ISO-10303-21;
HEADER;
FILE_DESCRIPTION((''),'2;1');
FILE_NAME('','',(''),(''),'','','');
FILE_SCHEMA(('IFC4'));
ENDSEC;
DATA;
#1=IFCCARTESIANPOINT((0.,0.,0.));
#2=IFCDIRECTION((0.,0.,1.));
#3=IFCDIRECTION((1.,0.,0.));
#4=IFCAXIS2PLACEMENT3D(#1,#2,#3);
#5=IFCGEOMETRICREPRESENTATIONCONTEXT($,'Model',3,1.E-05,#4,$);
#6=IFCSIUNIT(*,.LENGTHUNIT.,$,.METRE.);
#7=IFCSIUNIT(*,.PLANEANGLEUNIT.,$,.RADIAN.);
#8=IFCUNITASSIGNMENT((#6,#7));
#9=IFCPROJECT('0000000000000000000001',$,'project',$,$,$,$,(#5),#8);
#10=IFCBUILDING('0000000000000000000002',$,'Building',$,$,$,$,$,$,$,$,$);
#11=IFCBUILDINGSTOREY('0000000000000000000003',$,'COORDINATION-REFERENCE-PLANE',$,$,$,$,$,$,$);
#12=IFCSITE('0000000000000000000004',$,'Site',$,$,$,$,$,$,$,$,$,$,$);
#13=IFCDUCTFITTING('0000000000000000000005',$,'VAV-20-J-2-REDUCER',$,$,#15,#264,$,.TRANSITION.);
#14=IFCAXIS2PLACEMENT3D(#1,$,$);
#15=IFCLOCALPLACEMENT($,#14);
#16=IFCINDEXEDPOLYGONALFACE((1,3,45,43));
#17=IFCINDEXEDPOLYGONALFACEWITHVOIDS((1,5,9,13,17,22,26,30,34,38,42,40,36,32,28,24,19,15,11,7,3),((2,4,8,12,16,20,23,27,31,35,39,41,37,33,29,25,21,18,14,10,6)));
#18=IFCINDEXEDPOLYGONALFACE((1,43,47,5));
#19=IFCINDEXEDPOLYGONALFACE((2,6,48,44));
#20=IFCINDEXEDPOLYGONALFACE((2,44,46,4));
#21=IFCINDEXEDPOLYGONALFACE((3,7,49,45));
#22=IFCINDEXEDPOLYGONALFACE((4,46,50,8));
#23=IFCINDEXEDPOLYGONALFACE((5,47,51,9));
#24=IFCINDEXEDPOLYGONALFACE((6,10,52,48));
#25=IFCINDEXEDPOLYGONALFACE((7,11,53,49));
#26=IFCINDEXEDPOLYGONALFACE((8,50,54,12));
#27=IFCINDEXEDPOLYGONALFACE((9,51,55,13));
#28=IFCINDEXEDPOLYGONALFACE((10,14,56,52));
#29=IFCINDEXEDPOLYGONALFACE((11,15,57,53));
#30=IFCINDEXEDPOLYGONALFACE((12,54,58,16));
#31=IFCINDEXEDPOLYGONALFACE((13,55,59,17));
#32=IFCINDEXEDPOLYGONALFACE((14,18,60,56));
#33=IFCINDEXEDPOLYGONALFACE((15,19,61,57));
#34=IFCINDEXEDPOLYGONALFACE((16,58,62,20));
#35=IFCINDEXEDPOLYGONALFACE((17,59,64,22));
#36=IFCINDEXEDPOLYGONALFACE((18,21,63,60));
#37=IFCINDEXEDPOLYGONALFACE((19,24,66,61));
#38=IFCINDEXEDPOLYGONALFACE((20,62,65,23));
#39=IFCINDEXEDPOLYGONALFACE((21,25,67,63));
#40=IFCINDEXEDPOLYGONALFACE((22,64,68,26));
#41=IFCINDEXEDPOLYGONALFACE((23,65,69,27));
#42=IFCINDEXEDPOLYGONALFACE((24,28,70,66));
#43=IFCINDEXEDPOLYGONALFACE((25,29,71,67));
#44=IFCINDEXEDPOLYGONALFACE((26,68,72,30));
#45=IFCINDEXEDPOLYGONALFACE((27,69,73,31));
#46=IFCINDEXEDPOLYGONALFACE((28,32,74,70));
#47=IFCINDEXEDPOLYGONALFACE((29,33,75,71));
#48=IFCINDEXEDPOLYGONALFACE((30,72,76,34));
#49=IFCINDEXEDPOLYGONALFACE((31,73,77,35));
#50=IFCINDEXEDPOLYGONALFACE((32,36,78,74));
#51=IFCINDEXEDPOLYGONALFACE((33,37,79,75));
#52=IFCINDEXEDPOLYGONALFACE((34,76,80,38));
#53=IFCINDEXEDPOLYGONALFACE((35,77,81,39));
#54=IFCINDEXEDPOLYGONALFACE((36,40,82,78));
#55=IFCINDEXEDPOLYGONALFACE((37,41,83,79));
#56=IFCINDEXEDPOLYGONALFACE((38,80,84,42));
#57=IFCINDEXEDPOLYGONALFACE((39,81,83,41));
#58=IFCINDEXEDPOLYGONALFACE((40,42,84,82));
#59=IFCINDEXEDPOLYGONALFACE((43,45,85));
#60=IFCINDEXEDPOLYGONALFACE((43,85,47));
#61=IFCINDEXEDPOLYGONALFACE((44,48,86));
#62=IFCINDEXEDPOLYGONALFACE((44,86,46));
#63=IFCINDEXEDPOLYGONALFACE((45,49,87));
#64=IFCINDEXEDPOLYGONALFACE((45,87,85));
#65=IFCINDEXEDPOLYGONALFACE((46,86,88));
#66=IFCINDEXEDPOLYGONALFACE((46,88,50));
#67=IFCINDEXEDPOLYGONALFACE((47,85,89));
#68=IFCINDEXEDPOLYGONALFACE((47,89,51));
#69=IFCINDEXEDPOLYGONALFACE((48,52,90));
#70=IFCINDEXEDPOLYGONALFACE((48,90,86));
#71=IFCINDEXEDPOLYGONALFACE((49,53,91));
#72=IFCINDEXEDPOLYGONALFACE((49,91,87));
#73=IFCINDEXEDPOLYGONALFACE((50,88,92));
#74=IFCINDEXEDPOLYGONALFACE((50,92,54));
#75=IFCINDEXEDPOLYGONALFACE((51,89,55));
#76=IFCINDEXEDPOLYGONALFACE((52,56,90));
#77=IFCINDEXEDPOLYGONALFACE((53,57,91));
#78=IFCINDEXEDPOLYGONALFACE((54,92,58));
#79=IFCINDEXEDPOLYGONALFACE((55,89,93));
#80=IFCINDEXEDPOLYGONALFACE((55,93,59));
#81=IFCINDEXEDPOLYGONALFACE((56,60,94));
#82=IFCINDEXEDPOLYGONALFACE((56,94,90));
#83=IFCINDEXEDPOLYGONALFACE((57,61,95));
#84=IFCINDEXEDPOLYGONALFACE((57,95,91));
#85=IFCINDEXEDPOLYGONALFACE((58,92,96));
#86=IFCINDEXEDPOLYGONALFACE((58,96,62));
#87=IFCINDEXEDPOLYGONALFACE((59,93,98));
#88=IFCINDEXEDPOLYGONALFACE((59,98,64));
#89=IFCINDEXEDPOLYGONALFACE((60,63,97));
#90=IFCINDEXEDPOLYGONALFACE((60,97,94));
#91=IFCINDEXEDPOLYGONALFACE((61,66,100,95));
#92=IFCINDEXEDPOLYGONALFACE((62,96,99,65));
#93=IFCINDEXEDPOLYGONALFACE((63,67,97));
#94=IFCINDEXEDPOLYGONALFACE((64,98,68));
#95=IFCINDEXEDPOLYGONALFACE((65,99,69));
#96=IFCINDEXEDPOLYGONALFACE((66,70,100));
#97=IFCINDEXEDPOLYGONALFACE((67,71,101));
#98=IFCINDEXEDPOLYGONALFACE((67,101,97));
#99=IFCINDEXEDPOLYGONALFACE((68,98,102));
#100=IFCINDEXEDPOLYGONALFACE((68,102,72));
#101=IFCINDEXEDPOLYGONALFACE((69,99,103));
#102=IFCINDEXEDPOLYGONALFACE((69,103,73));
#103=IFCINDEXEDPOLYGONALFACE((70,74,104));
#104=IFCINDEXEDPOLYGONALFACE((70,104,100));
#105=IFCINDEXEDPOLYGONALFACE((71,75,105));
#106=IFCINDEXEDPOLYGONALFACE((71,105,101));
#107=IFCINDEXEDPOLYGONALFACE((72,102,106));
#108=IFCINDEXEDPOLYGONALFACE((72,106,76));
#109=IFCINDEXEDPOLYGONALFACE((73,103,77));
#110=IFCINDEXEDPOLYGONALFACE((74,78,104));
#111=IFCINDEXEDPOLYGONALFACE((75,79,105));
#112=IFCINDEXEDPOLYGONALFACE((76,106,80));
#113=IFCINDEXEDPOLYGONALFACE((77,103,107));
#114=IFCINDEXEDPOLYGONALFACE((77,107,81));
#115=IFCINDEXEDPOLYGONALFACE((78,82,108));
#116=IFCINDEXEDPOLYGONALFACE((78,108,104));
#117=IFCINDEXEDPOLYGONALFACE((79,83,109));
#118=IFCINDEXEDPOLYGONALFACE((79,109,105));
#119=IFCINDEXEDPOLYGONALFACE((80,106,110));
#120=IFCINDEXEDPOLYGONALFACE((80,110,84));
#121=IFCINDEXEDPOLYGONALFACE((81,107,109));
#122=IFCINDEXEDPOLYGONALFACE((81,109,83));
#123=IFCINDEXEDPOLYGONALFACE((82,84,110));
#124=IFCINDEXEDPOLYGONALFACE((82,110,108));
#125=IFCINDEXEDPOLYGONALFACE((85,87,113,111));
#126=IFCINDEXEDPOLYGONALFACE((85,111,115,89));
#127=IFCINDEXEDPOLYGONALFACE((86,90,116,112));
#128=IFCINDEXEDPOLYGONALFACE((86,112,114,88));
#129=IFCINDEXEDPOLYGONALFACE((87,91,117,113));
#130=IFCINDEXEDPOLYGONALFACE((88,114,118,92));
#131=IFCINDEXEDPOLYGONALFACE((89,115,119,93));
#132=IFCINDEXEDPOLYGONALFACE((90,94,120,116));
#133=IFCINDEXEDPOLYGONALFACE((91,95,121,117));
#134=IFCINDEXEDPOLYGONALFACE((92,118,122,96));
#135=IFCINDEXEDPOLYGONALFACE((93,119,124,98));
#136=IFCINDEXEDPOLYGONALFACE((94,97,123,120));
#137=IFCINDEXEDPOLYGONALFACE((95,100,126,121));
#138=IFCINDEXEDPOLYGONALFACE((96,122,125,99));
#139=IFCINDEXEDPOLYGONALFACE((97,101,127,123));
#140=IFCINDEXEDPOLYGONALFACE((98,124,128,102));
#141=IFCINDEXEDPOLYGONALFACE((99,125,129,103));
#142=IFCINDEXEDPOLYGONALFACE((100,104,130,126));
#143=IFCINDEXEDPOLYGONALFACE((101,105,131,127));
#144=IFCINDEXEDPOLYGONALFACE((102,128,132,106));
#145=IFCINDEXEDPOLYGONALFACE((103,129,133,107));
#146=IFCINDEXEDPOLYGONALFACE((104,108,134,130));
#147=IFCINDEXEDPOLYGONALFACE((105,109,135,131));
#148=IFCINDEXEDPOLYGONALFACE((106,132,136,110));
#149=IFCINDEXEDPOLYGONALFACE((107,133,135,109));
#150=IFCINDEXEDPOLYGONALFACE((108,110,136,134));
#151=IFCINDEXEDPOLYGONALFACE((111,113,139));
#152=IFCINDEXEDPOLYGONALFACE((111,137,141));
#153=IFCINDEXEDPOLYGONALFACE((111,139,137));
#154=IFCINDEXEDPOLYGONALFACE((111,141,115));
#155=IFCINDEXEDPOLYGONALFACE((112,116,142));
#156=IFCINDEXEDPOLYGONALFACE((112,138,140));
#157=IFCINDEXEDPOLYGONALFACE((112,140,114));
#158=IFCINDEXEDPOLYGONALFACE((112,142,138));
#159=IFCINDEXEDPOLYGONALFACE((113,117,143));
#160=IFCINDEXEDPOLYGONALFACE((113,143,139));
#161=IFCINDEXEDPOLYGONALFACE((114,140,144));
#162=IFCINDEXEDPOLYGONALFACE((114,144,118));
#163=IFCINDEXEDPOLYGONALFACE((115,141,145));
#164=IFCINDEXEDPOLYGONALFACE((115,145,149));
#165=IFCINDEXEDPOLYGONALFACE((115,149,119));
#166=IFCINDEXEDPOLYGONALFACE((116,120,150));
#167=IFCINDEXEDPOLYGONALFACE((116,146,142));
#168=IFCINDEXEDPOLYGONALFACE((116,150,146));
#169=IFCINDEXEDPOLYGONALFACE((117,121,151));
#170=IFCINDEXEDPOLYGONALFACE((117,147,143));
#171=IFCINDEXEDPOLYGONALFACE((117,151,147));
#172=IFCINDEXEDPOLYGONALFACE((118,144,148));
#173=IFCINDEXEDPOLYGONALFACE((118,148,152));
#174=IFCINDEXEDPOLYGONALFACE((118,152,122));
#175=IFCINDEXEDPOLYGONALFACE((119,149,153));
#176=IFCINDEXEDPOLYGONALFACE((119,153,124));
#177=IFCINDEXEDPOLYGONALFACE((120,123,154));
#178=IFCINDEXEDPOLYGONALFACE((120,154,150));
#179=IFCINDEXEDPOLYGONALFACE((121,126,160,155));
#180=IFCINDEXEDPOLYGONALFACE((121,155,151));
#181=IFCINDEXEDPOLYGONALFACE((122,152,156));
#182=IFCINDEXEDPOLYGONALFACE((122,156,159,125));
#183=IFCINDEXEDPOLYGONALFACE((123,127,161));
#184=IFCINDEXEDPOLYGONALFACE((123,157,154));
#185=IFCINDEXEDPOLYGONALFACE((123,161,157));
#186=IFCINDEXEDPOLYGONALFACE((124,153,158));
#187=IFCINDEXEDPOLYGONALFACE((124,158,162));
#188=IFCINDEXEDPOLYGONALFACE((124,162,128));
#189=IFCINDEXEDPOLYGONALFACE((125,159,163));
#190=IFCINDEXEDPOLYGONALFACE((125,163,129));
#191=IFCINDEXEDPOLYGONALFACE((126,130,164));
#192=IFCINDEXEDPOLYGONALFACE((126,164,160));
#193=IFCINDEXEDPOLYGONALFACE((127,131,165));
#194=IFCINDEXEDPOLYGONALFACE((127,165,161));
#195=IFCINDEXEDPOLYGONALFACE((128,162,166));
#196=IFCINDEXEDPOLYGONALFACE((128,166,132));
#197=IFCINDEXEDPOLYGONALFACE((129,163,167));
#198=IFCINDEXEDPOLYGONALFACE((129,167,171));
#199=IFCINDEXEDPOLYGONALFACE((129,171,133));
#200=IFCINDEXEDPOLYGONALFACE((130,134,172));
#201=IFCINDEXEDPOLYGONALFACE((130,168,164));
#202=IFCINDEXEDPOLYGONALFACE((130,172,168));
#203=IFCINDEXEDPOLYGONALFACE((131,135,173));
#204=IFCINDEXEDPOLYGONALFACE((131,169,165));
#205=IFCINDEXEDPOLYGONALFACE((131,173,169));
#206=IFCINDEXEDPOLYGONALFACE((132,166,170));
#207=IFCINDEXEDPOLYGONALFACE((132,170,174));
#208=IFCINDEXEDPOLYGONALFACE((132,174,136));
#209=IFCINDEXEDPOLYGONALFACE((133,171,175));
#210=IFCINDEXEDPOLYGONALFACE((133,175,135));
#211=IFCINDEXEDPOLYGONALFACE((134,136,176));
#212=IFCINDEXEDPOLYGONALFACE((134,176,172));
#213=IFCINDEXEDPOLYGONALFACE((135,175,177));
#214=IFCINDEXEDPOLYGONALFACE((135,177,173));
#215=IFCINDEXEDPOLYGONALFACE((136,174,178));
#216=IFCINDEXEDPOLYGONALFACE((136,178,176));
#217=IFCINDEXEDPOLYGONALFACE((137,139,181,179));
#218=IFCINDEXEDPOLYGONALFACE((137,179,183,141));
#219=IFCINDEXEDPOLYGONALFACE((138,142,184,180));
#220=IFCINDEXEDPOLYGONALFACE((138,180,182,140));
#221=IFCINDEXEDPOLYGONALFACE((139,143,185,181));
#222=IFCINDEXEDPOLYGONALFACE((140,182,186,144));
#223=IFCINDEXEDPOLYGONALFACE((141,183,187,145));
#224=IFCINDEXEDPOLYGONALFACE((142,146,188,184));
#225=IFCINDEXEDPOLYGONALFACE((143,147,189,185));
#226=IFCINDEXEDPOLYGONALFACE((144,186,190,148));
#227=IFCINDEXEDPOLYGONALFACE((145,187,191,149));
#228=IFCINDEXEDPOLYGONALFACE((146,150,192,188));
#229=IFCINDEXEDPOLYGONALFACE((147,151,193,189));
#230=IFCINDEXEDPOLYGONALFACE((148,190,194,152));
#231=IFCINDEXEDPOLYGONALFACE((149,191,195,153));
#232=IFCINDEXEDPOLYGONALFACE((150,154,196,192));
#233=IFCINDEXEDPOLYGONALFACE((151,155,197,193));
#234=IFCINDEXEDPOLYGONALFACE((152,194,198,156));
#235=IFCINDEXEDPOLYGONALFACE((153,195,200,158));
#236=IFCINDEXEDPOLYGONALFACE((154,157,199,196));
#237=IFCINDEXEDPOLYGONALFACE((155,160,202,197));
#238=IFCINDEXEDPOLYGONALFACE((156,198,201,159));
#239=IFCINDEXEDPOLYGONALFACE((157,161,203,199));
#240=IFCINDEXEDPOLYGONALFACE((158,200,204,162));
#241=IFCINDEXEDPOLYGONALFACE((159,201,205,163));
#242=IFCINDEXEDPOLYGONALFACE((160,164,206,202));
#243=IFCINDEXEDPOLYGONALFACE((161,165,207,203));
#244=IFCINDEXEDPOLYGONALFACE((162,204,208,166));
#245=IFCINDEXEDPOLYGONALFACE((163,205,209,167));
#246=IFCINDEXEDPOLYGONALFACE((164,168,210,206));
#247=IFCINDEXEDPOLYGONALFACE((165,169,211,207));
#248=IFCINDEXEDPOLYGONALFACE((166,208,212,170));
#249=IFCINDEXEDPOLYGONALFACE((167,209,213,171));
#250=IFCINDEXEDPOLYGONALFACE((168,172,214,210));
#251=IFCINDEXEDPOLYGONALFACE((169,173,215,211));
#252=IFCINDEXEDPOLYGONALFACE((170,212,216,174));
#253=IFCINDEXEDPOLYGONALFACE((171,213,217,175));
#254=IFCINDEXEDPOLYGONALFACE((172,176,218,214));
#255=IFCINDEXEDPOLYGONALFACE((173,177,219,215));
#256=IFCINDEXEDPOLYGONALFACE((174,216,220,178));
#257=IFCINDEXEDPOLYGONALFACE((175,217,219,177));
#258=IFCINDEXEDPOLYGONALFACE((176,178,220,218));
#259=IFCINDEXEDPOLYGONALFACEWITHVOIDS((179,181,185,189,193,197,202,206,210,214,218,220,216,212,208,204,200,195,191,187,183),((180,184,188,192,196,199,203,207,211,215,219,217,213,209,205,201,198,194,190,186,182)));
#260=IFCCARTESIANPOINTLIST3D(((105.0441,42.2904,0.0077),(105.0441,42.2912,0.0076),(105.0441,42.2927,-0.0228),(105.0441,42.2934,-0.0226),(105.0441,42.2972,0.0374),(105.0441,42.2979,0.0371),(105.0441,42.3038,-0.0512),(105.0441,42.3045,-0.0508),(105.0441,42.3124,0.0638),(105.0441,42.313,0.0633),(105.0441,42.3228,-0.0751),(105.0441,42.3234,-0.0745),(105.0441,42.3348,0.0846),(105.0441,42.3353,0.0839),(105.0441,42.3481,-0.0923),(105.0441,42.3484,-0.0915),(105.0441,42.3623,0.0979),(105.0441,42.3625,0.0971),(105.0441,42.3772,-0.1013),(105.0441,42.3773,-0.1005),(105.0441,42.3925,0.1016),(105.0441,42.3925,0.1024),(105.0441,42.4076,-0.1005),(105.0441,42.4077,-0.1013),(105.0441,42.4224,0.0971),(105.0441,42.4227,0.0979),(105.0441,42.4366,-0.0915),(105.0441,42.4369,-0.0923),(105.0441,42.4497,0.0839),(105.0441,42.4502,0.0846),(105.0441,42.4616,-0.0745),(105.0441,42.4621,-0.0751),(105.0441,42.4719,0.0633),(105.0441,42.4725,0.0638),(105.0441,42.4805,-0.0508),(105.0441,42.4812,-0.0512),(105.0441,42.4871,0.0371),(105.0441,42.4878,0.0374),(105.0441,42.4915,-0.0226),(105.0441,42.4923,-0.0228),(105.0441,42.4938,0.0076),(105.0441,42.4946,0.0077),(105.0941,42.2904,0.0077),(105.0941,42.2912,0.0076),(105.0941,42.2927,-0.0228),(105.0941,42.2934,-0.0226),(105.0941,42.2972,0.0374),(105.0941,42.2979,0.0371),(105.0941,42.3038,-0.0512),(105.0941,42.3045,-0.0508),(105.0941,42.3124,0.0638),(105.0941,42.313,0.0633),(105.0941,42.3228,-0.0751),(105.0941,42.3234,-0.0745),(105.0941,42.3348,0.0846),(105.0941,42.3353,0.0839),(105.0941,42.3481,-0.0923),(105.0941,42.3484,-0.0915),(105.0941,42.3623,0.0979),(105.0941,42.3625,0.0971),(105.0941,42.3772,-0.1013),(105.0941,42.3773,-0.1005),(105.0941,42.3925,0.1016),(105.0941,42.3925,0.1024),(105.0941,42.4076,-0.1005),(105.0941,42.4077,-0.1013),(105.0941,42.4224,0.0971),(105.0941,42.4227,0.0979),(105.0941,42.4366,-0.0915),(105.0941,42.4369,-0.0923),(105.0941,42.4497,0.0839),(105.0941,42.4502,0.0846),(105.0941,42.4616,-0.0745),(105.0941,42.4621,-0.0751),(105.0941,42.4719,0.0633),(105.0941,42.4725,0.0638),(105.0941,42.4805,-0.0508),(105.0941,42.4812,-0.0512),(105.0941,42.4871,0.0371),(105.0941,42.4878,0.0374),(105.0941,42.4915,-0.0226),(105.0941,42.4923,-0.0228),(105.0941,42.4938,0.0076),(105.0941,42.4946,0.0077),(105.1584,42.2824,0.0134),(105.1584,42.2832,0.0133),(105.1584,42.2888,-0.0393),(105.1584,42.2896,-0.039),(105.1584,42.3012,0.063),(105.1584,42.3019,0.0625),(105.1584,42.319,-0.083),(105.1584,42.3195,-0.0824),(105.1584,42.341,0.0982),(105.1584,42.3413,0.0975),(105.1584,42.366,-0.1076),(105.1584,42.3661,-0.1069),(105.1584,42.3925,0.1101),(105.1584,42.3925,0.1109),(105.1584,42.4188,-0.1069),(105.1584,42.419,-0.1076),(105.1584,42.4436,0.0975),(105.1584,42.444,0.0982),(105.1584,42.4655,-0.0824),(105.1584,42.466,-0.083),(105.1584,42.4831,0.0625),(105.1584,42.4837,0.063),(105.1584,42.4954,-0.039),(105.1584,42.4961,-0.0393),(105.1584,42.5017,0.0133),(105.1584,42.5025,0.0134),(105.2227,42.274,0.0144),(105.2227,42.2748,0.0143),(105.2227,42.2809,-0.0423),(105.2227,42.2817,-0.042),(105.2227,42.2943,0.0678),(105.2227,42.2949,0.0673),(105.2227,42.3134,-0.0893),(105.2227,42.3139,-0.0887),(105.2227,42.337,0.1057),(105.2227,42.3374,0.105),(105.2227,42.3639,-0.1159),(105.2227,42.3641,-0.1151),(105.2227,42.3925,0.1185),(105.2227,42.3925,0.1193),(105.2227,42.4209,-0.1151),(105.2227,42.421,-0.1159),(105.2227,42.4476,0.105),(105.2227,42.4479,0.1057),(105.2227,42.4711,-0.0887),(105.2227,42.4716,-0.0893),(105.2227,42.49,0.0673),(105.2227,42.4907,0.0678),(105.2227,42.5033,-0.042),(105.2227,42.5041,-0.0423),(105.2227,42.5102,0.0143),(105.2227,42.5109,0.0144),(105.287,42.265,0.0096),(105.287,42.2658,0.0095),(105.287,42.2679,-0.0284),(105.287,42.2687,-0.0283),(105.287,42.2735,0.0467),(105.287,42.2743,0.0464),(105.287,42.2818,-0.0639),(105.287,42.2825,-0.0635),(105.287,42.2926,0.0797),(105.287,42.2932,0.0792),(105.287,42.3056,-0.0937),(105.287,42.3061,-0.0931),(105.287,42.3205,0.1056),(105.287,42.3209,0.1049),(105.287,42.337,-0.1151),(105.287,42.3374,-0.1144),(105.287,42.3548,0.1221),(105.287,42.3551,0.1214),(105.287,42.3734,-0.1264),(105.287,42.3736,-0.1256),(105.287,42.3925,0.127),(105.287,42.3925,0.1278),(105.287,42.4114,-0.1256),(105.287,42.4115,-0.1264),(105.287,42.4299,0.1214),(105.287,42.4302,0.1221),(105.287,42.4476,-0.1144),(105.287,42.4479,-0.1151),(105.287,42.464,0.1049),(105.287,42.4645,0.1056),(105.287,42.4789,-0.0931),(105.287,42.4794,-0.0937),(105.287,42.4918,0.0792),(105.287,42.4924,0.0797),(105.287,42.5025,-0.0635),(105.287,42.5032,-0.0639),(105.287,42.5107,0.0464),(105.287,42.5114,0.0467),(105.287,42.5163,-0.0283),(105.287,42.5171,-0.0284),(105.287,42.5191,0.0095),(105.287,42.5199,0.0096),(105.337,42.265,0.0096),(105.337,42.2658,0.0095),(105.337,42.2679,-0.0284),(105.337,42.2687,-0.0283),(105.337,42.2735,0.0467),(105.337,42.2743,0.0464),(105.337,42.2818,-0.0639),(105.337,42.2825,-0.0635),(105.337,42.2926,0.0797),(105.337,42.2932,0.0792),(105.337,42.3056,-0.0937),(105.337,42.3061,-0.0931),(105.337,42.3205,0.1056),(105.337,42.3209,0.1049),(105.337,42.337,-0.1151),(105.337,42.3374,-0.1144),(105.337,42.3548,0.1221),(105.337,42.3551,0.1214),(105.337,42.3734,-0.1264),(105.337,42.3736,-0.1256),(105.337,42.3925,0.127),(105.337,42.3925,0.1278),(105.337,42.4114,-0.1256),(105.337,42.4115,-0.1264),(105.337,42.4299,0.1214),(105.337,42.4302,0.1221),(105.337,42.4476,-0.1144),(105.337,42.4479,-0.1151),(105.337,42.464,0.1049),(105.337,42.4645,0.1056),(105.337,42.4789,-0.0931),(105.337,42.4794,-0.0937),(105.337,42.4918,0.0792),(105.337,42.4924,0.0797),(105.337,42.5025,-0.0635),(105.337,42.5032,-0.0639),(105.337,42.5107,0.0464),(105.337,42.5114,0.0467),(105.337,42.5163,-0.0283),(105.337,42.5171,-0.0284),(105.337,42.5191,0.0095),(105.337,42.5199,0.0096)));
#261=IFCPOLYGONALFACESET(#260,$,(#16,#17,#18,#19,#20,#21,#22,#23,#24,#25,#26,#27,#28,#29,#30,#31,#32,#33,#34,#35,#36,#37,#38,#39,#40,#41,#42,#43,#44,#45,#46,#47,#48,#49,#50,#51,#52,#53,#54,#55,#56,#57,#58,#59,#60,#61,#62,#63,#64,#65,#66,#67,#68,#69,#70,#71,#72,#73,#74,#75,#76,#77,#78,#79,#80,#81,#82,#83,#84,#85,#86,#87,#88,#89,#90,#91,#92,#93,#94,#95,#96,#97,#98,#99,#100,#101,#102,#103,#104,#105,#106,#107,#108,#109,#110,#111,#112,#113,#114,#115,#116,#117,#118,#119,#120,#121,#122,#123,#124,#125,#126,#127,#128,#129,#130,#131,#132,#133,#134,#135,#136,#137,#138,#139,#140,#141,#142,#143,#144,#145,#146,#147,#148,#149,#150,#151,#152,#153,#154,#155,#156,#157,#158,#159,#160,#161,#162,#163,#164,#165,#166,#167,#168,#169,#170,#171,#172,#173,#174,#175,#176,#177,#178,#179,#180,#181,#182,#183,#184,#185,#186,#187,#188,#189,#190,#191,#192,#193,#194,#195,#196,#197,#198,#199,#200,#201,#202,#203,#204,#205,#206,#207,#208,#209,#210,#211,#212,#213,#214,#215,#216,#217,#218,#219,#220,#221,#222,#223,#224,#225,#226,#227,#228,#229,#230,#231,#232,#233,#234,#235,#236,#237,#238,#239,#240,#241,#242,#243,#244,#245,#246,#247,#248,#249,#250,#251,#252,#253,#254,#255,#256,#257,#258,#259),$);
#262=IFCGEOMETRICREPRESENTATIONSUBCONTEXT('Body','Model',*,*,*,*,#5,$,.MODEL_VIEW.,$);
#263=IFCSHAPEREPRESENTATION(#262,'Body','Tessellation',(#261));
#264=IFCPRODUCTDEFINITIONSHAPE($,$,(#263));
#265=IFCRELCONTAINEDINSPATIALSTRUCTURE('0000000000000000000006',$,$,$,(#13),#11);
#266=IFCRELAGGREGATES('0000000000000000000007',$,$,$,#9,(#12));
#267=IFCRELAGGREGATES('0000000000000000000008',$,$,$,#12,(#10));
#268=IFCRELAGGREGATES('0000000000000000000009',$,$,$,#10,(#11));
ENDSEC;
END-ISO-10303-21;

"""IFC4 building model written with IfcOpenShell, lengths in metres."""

from ifc_helpers import new_model, entity, si_unit, frame, origin_with_axes, place, context, subcontext, project, spatial, element, save


model = new_model("IFC4")

# Units and contexts
model_context = context("Model", 3, precision=1e-05, world=origin_with_axes())
body_context_1 = subcontext(model_context, "Body", "Model", "MODEL_VIEW")
ifc_project = project(units=[si_unit("LENGTHUNIT", "METRE"), si_unit("PLANEANGLEUNIT", "RADIAN")], contexts=[model_context])

# Site, building, storey
site = spatial("IfcSite", under=ifc_project, Name="Site")
building = spatial("IfcBuilding", under=site, Name="Building")
storey = spatial("IfcBuildingStorey", under=building, Name="COORDINATION-REFERENCE-PLANE")

# Duct fitting
for number, where, z_axis, x_axis, name in (
    (1, (105.337, 42.3925, 0.0), (0.0, -1.0, 0.0), (0.0, 0.0, 1.0), "VAV-20-J-2-REDUCER"),
):
    element("IfcDuctFitting", number, at=place(None, frame(where, z_axis=z_axis, x_axis=x_axis)), inside=storey, Name=name, PredefinedType="TRANSITION", context=body_context_1, shape_type="SweptSolid", body=[
        entity("IfcRevolvedAreaSolid", entity("IfcArbitraryClosedProfileDef", "AREA", None, entity("IfcPolyline", [entity("IfcCartesianPoint", [0.1278, 0.0]), entity("IfcCartesianPoint", [0.1278, 0.05]), entity("IfcCartesianPoint", [0.1024, 0.2429]), entity("IfcCartesianPoint", [0.1024, 0.2929]), entity("IfcCartesianPoint", [0.1016, 0.2929]), entity("IfcCartesianPoint", [0.1016, 0.2429]), entity("IfcCartesianPoint", [0.127, 0.05]), entity("IfcCartesianPoint", [0.127, 0.0]), entity("IfcCartesianPoint", [0.1278, 0.0])])), entity("IfcAxis2Placement3D", entity("IfcCartesianPoint", [0.0, 0.0, 0.0])), entity("IfcAxis1Placement", entity("IfcCartesianPoint", [0.0, 0.0, 0.0]), entity("IfcDirection", [0.0, 1.0, 0.0])), 6.283185),
    ])

save(model, "model.ifc")
